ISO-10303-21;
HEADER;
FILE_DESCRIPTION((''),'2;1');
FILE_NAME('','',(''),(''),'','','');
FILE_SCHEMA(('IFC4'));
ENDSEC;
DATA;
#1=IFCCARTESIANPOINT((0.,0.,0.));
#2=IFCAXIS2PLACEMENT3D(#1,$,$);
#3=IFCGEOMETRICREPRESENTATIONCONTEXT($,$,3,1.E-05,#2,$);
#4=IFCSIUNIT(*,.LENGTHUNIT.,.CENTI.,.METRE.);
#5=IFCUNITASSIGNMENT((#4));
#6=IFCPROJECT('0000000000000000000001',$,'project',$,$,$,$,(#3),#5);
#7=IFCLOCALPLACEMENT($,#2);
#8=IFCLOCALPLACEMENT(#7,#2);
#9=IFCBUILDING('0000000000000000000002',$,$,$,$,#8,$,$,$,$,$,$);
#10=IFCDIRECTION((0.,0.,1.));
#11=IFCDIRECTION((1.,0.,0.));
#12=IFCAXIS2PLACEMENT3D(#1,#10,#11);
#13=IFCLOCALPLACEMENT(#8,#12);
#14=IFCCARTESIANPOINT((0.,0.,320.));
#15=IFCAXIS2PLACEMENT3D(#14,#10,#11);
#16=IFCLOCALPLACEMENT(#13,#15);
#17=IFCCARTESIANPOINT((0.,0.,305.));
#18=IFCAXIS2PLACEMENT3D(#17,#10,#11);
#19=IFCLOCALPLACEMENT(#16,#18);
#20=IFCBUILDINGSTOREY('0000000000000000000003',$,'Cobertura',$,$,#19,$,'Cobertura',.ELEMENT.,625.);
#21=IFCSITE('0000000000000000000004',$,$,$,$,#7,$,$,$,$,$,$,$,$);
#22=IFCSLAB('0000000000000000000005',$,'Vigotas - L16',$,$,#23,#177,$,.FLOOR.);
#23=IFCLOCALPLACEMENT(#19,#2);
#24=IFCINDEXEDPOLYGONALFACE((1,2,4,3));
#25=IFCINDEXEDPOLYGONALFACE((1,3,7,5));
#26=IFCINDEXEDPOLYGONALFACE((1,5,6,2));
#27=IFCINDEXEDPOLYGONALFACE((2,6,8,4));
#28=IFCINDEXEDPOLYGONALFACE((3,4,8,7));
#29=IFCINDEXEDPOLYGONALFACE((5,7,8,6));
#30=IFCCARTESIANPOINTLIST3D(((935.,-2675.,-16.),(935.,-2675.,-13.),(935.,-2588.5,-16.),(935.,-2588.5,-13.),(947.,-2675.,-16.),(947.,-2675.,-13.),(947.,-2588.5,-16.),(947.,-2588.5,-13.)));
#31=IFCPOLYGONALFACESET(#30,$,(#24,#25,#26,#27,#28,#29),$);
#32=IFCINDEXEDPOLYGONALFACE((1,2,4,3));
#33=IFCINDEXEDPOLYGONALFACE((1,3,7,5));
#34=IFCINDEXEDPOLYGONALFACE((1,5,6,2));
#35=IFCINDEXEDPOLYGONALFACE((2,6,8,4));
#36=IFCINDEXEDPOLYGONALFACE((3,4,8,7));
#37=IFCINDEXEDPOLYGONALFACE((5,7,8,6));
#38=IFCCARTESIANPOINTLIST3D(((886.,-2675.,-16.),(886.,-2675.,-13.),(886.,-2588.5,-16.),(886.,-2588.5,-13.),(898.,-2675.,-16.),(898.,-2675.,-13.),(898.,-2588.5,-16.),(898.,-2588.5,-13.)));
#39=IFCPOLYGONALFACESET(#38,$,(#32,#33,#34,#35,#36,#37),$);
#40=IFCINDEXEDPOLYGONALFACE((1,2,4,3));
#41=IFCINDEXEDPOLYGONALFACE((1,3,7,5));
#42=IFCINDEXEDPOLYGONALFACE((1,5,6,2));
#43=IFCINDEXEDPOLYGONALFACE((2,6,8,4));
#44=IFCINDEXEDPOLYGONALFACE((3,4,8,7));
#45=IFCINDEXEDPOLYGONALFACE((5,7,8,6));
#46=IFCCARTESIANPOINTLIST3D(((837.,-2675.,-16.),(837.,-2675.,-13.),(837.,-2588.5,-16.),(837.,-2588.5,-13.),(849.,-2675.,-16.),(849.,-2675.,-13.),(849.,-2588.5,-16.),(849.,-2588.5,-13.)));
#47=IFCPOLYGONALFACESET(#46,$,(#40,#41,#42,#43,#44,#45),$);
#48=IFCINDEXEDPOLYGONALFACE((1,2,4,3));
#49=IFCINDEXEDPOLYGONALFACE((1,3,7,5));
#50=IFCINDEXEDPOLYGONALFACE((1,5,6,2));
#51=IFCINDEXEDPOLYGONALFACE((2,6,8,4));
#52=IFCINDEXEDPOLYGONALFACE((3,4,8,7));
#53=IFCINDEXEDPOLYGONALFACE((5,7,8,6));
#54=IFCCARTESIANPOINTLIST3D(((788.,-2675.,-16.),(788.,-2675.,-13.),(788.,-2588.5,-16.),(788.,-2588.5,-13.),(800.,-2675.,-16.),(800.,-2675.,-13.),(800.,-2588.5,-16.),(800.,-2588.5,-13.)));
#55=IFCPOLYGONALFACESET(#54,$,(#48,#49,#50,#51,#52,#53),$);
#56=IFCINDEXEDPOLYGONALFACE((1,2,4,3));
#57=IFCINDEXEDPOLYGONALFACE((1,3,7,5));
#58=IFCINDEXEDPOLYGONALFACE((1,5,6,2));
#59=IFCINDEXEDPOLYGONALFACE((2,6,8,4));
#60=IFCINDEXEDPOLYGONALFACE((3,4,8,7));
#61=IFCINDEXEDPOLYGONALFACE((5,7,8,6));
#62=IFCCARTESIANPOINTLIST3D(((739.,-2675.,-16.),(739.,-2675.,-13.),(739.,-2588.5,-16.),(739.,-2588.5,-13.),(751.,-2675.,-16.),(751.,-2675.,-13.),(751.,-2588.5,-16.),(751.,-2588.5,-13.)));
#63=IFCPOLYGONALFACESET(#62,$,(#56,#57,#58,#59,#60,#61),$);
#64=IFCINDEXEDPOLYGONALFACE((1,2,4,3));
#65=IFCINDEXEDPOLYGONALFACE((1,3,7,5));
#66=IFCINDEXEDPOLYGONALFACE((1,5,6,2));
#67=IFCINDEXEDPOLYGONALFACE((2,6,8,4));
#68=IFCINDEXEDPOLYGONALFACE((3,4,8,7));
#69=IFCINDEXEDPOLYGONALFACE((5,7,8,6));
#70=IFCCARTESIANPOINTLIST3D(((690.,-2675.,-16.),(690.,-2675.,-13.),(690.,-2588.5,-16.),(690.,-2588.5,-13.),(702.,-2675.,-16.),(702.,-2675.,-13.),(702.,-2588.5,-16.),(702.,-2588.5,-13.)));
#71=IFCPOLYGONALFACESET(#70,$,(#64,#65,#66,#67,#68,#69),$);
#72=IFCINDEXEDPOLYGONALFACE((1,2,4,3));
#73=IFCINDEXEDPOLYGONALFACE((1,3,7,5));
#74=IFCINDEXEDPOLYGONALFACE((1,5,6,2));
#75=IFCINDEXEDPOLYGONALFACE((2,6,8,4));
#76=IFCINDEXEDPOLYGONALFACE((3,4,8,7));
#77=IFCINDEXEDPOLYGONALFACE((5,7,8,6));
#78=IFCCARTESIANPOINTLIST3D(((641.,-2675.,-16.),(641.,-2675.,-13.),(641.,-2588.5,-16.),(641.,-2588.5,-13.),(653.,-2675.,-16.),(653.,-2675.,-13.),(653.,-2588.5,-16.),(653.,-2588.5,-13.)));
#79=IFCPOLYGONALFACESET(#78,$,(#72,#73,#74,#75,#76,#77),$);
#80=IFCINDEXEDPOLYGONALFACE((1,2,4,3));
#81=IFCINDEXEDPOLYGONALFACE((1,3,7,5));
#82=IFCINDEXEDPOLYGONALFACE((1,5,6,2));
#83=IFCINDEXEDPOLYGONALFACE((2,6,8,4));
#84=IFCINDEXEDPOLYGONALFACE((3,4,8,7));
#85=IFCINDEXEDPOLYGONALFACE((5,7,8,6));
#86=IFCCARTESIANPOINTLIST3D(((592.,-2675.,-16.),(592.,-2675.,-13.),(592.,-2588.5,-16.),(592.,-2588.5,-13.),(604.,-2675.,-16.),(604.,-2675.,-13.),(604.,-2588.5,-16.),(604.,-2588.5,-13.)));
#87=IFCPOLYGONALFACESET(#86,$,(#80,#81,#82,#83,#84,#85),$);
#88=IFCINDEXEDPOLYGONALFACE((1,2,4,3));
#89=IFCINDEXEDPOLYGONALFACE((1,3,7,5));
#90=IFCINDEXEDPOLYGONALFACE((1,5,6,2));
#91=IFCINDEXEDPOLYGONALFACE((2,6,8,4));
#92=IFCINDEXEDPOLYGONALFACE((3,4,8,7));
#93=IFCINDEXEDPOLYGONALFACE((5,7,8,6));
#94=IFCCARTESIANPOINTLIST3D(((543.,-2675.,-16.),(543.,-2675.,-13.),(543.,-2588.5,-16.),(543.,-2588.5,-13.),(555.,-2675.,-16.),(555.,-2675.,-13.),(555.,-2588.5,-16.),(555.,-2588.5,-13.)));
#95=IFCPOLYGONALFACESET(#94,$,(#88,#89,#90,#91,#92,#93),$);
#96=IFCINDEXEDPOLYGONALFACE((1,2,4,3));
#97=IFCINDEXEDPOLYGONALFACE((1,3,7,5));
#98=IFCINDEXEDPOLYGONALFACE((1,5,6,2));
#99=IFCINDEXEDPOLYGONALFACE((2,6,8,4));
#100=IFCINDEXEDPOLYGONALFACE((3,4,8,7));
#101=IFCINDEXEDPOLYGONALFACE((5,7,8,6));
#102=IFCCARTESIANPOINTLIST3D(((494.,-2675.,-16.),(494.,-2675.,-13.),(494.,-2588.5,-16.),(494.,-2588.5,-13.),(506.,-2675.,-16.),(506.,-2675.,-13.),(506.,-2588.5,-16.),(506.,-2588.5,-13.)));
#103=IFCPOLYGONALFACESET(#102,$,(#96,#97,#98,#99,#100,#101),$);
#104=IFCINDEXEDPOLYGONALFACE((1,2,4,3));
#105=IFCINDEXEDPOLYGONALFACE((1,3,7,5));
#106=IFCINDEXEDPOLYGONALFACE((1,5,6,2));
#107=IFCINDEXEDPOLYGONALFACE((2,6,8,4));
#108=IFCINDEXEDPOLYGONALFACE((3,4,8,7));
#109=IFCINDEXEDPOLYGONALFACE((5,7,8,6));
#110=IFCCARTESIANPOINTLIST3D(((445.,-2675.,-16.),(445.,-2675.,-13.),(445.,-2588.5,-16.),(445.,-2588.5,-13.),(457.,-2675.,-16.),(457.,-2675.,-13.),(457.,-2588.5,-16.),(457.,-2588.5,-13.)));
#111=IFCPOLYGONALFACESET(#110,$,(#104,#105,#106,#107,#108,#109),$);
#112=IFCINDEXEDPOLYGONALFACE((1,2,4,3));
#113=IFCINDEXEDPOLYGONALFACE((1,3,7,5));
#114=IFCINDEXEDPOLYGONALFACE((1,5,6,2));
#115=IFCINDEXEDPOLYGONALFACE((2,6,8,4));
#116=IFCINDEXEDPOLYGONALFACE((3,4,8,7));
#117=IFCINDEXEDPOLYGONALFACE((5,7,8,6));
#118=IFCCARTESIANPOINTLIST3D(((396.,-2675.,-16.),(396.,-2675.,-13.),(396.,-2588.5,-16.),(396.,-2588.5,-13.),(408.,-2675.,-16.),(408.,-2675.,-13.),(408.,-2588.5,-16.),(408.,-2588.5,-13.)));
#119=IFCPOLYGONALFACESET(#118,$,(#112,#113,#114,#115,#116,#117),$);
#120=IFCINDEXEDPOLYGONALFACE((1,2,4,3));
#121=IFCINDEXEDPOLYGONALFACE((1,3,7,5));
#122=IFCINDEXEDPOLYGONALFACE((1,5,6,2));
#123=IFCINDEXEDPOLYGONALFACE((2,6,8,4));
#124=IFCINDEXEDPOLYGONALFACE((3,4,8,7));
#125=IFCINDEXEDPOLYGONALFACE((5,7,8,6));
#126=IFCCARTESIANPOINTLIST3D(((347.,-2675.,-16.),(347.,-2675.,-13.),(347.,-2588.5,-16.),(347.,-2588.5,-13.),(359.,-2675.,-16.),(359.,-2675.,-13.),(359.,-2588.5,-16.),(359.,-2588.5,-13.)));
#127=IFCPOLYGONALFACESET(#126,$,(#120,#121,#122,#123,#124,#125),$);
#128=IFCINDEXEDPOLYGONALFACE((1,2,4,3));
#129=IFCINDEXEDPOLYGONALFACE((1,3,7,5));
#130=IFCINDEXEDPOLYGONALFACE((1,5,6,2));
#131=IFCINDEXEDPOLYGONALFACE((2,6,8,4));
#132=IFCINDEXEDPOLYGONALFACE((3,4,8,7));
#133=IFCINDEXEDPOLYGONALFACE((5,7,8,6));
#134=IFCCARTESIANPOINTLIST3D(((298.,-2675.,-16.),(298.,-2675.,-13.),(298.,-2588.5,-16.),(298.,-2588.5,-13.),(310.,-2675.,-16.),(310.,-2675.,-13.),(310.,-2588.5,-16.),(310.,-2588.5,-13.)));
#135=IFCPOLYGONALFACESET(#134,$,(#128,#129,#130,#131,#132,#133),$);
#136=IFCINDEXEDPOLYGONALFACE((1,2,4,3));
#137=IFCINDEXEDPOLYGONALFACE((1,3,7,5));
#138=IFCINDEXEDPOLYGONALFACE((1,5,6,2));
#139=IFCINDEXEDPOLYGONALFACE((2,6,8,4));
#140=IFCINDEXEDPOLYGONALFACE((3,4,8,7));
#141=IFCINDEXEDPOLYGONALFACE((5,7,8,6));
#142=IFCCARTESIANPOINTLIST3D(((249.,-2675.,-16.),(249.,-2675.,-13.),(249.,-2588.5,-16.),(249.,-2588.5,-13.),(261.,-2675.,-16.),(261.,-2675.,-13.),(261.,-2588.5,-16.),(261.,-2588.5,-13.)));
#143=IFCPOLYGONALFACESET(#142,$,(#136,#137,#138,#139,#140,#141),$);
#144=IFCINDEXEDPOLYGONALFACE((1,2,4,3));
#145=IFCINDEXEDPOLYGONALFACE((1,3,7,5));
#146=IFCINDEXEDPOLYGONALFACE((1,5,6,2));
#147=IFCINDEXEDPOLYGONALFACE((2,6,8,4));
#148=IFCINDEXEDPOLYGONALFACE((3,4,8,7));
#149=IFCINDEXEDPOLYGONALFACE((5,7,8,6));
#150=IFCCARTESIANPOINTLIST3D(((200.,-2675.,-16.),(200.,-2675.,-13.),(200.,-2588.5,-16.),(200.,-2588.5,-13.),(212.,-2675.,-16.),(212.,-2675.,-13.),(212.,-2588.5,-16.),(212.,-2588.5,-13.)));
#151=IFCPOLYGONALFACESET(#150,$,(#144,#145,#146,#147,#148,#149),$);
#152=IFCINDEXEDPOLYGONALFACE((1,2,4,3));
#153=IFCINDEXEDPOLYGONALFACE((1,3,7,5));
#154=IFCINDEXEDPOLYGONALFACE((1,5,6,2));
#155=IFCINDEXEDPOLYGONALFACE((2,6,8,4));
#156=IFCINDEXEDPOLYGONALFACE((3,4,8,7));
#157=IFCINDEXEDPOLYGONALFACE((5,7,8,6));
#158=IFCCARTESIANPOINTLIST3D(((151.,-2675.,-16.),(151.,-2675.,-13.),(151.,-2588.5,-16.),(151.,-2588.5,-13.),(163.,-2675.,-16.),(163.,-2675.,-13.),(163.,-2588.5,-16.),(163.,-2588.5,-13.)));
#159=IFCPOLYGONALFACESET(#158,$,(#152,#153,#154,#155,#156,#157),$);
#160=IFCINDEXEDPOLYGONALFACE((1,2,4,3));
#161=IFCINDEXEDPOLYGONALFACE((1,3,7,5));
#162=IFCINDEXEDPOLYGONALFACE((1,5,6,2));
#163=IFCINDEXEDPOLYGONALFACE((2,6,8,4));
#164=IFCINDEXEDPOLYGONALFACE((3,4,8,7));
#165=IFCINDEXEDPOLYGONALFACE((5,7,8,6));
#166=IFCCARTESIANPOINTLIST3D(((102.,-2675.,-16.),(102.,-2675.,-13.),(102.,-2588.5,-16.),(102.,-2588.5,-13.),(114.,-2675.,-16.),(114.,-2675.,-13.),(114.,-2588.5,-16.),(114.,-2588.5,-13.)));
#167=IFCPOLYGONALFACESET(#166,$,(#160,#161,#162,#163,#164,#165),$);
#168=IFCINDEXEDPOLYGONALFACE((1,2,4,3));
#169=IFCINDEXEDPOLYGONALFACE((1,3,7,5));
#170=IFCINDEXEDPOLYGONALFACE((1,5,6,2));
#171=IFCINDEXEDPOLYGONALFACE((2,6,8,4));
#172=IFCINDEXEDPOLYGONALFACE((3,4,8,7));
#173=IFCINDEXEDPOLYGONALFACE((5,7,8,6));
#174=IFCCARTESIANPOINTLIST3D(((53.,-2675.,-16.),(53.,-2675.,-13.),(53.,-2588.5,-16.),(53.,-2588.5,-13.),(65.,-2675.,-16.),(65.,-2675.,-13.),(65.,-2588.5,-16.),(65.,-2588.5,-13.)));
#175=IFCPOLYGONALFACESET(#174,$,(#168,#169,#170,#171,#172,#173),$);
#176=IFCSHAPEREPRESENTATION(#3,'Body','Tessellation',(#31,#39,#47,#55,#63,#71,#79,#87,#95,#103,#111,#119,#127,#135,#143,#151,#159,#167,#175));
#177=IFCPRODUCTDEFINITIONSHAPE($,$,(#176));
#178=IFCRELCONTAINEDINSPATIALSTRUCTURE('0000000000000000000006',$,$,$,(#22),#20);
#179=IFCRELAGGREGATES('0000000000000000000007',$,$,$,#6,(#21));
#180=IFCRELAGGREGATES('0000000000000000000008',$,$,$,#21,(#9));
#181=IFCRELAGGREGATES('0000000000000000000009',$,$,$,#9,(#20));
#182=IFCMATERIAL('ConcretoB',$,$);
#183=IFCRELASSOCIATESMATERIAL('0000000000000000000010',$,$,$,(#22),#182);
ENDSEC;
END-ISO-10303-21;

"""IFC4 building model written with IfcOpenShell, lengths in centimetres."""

from ifc_helpers import new_model, si_unit, frame, origin, origin_with_axes, place, context, project, spatial, polyline, outline, extrude, material, element, save


model = new_model("IFC4")

# Units and contexts
context_of_model = context(None, 3, precision=1e-05, world=origin())
ifc_project = project(units=[si_unit("LENGTHUNIT", "METRE", prefix="CENTI")], contexts=[context_of_model])

# Site, building, storey
site_placement = place(None, origin())
site = spatial("IfcSite", under=ifc_project, at=site_placement)
building_placement = place(site_placement, origin())
building = spatial("IfcBuilding", under=site, at=building_placement)
placement_1 = place(building_placement, origin_with_axes())
placement_2 = place(placement_1, frame((0.0, 0.0, 320.0), z_axis=(0.0, 0.0, 1.0), x_axis=(1.0, 0.0, 0.0)))
storey_placement = place(placement_2, frame((0.0, 0.0, 305.0), z_axis=(0.0, 0.0, 1.0), x_axis=(1.0, 0.0, 0.0)))
storey = spatial("IfcBuildingStorey", under=building, at=storey_placement, Name="Cobertura", LongName="Cobertura", CompositionType="ELEMENT", Elevation=625.0)

# Shared definitions
ifc_material = material(Name="ConcretoB")

# Slab
slab_1_placement = place(storey_placement, frame((500.0, -2631.75, -13.0), z_axis=(0.0, 0.0, 1.0), x_axis=(1.0, 0.0, 0.0)))
element("IfcSlab", 1, at=slab_1_placement, inside=storey, material=ifc_material, Name="Vigotas - L16", PredefinedType="FLOOR", context=context_of_model, shape_type="SolidModel", body=[
    extrude(outline(polyline([(6.0, 1.5), (-6.0, 1.5), (-6.0, -1.5), (6.0, -1.5), (6.0, 1.5), (6.0, 1.5)])), frame((441.0, -43.25, -1.5), z_axis=(0.0, 1.0, 0.0), x_axis=(1.0, 0.0, 0.0)), (0.0, 0.0, 1.0), 86.5),
    extrude(outline(polyline([(6.0, 1.5), (-6.0, 1.5), (-6.0, -1.5), (6.0, -1.5), (6.0, 1.5), (6.0, 1.5)])), frame((392.0, -43.25, -1.5), z_axis=(0.0, 1.0, 0.0), x_axis=(1.0, 0.0, 0.0)), (0.0, 0.0, 1.0), 86.5),
    extrude(outline(polyline([(6.0, 1.5), (-6.0, 1.5), (-6.0, -1.5), (6.0, -1.5), (6.0, 1.5), (6.0, 1.5)])), frame((343.0, -43.25, -1.5), z_axis=(0.0, 1.0, 0.0), x_axis=(1.0, 0.0, 0.0)), (0.0, 0.0, 1.0), 86.5),
    extrude(outline(polyline([(6.0, 1.5), (-6.0, 1.5), (-6.0, -1.5), (6.0, -1.5), (6.0, 1.5), (6.0, 1.5)])), frame((294.0, -43.25, -1.5), z_axis=(0.0, 1.0, 0.0), x_axis=(1.0, 0.0, 0.0)), (0.0, 0.0, 1.0), 86.5),
    extrude(outline(polyline([(6.0, 1.5), (-6.0, 1.5), (-6.0, -1.5), (6.0, -1.5), (6.0, 1.5), (6.0, 1.5)])), frame((245.0, -43.25, -1.5), z_axis=(0.0, 1.0, 0.0), x_axis=(1.0, 0.0, 0.0)), (0.0, 0.0, 1.0), 86.5),
    extrude(outline(polyline([(6.0, 1.5), (-6.0, 1.5), (-6.0, -1.5), (6.0, -1.5), (6.0, 1.5), (6.0, 1.5)])), frame((196.0, -43.25, -1.5), z_axis=(0.0, 1.0, 0.0), x_axis=(1.0, 0.0, 0.0)), (0.0, 0.0, 1.0), 86.5),
    extrude(outline(polyline([(6.0, 1.5), (-6.0, 1.5), (-6.0, -1.5), (6.0, -1.5), (6.0, 1.5), (6.0, 1.5)])), frame((147.0, -43.25, -1.5), z_axis=(0.0, 1.0, 0.0), x_axis=(1.0, 0.0, 0.0)), (0.0, 0.0, 1.0), 86.5),
    extrude(outline(polyline([(6.0, 1.5), (-6.0, 1.5), (-6.0, -1.5), (6.0, -1.5), (6.0, 1.5), (6.0, 1.5)])), frame((98.0, -43.25, -1.5), z_axis=(0.0, 1.0, 0.0), x_axis=(1.0, 0.0, 0.0)), (0.0, 0.0, 1.0), 86.5),
    extrude(outline(polyline([(6.0, 1.5), (-6.0, 1.5), (-6.0, -1.5), (6.0, -1.5), (6.0, 1.5), (6.0, 1.5)])), frame((49.0, -43.25, -1.5), z_axis=(0.0, 1.0, 0.0), x_axis=(1.0, 0.0, 0.0)), (0.0, 0.0, 1.0), 86.5),
    extrude(outline(polyline([(6.0, 1.5), (-6.0, 1.5), (-6.0, -1.5), (6.0, -1.5), (6.0, 1.5), (6.0, 1.5)])), frame((0.0, -43.25, -1.5), z_axis=(0.0, 1.0, 0.0), x_axis=(1.0, 0.0, 0.0)), (0.0, 0.0, 1.0), 86.5),
    extrude(outline(polyline([(6.0, 1.5), (-6.0, 1.5), (-6.0, -1.5), (6.0, -1.5), (6.0, 1.5), (6.0, 1.5)])), frame((-49.0, -43.25, -1.5), z_axis=(0.0, 1.0, 0.0), x_axis=(1.0, 0.0, 0.0)), (0.0, 0.0, 1.0), 86.5),
    extrude(outline(polyline([(6.0, 1.5), (-6.0, 1.5), (-6.0, -1.5), (6.0, -1.5), (6.0, 1.5), (6.0, 1.5)])), frame((-98.0, -43.25, -1.5), z_axis=(0.0, 1.0, 0.0), x_axis=(1.0, 0.0, 0.0)), (0.0, 0.0, 1.0), 86.5),
    extrude(outline(polyline([(6.0, 1.5), (-6.0, 1.5), (-6.0, -1.5), (6.0, -1.5), (6.0, 1.5), (6.0, 1.5)])), frame((-147.0, -43.25, -1.5), z_axis=(0.0, 1.0, 0.0), x_axis=(1.0, 0.0, 0.0)), (0.0, 0.0, 1.0), 86.5),
    extrude(outline(polyline([(6.0, 1.5), (-6.0, 1.5), (-6.0, -1.5), (6.0, -1.5), (6.0, 1.5), (6.0, 1.5)])), frame((-196.0, -43.25, -1.5), z_axis=(0.0, 1.0, 0.0), x_axis=(1.0, 0.0, 0.0)), (0.0, 0.0, 1.0), 86.5),
    extrude(outline(polyline([(6.0, 1.5), (-6.0, 1.5), (-6.0, -1.5), (6.0, -1.5), (6.0, 1.5), (6.0, 1.5)])), frame((-245.0, -43.25, -1.5), z_axis=(0.0, 1.0, 0.0), x_axis=(1.0, 0.0, 0.0)), (0.0, 0.0, 1.0), 86.5),
    extrude(outline(polyline([(6.0, 1.5), (-6.0, 1.5), (-6.0, -1.5), (6.0, -1.5), (6.0, 1.5), (6.0, 1.5)])), frame((-294.0, -43.25, -1.5), z_axis=(0.0, 1.0, 0.0), x_axis=(1.0, 0.0, 0.0)), (0.0, 0.0, 1.0), 86.5),
    extrude(outline(polyline([(6.0, 1.5), (-6.0, 1.5), (-6.0, -1.5), (6.0, -1.5), (6.0, 1.5), (6.0, 1.5)])), frame((-343.0, -43.25, -1.5), z_axis=(0.0, 1.0, 0.0), x_axis=(1.0, 0.0, 0.0)), (0.0, 0.0, 1.0), 86.5),
    extrude(outline(polyline([(6.0, 1.5), (-6.0, 1.5), (-6.0, -1.5), (6.0, -1.5), (6.0, 1.5), (6.0, 1.5)])), frame((-392.0, -43.25, -1.5), z_axis=(0.0, 1.0, 0.0), x_axis=(1.0, 0.0, 0.0)), (0.0, 0.0, 1.0), 86.5),
    extrude(outline(polyline([(6.0, 1.5), (-6.0, 1.5), (-6.0, -1.5), (6.0, -1.5), (6.0, 1.5), (6.0, 1.5)])), frame((-441.0, -43.25, -1.5), z_axis=(0.0, 1.0, 0.0), x_axis=(1.0, 0.0, 0.0)), (0.0, 0.0, 1.0), 86.5),
])

save(model, "model.ifc")
